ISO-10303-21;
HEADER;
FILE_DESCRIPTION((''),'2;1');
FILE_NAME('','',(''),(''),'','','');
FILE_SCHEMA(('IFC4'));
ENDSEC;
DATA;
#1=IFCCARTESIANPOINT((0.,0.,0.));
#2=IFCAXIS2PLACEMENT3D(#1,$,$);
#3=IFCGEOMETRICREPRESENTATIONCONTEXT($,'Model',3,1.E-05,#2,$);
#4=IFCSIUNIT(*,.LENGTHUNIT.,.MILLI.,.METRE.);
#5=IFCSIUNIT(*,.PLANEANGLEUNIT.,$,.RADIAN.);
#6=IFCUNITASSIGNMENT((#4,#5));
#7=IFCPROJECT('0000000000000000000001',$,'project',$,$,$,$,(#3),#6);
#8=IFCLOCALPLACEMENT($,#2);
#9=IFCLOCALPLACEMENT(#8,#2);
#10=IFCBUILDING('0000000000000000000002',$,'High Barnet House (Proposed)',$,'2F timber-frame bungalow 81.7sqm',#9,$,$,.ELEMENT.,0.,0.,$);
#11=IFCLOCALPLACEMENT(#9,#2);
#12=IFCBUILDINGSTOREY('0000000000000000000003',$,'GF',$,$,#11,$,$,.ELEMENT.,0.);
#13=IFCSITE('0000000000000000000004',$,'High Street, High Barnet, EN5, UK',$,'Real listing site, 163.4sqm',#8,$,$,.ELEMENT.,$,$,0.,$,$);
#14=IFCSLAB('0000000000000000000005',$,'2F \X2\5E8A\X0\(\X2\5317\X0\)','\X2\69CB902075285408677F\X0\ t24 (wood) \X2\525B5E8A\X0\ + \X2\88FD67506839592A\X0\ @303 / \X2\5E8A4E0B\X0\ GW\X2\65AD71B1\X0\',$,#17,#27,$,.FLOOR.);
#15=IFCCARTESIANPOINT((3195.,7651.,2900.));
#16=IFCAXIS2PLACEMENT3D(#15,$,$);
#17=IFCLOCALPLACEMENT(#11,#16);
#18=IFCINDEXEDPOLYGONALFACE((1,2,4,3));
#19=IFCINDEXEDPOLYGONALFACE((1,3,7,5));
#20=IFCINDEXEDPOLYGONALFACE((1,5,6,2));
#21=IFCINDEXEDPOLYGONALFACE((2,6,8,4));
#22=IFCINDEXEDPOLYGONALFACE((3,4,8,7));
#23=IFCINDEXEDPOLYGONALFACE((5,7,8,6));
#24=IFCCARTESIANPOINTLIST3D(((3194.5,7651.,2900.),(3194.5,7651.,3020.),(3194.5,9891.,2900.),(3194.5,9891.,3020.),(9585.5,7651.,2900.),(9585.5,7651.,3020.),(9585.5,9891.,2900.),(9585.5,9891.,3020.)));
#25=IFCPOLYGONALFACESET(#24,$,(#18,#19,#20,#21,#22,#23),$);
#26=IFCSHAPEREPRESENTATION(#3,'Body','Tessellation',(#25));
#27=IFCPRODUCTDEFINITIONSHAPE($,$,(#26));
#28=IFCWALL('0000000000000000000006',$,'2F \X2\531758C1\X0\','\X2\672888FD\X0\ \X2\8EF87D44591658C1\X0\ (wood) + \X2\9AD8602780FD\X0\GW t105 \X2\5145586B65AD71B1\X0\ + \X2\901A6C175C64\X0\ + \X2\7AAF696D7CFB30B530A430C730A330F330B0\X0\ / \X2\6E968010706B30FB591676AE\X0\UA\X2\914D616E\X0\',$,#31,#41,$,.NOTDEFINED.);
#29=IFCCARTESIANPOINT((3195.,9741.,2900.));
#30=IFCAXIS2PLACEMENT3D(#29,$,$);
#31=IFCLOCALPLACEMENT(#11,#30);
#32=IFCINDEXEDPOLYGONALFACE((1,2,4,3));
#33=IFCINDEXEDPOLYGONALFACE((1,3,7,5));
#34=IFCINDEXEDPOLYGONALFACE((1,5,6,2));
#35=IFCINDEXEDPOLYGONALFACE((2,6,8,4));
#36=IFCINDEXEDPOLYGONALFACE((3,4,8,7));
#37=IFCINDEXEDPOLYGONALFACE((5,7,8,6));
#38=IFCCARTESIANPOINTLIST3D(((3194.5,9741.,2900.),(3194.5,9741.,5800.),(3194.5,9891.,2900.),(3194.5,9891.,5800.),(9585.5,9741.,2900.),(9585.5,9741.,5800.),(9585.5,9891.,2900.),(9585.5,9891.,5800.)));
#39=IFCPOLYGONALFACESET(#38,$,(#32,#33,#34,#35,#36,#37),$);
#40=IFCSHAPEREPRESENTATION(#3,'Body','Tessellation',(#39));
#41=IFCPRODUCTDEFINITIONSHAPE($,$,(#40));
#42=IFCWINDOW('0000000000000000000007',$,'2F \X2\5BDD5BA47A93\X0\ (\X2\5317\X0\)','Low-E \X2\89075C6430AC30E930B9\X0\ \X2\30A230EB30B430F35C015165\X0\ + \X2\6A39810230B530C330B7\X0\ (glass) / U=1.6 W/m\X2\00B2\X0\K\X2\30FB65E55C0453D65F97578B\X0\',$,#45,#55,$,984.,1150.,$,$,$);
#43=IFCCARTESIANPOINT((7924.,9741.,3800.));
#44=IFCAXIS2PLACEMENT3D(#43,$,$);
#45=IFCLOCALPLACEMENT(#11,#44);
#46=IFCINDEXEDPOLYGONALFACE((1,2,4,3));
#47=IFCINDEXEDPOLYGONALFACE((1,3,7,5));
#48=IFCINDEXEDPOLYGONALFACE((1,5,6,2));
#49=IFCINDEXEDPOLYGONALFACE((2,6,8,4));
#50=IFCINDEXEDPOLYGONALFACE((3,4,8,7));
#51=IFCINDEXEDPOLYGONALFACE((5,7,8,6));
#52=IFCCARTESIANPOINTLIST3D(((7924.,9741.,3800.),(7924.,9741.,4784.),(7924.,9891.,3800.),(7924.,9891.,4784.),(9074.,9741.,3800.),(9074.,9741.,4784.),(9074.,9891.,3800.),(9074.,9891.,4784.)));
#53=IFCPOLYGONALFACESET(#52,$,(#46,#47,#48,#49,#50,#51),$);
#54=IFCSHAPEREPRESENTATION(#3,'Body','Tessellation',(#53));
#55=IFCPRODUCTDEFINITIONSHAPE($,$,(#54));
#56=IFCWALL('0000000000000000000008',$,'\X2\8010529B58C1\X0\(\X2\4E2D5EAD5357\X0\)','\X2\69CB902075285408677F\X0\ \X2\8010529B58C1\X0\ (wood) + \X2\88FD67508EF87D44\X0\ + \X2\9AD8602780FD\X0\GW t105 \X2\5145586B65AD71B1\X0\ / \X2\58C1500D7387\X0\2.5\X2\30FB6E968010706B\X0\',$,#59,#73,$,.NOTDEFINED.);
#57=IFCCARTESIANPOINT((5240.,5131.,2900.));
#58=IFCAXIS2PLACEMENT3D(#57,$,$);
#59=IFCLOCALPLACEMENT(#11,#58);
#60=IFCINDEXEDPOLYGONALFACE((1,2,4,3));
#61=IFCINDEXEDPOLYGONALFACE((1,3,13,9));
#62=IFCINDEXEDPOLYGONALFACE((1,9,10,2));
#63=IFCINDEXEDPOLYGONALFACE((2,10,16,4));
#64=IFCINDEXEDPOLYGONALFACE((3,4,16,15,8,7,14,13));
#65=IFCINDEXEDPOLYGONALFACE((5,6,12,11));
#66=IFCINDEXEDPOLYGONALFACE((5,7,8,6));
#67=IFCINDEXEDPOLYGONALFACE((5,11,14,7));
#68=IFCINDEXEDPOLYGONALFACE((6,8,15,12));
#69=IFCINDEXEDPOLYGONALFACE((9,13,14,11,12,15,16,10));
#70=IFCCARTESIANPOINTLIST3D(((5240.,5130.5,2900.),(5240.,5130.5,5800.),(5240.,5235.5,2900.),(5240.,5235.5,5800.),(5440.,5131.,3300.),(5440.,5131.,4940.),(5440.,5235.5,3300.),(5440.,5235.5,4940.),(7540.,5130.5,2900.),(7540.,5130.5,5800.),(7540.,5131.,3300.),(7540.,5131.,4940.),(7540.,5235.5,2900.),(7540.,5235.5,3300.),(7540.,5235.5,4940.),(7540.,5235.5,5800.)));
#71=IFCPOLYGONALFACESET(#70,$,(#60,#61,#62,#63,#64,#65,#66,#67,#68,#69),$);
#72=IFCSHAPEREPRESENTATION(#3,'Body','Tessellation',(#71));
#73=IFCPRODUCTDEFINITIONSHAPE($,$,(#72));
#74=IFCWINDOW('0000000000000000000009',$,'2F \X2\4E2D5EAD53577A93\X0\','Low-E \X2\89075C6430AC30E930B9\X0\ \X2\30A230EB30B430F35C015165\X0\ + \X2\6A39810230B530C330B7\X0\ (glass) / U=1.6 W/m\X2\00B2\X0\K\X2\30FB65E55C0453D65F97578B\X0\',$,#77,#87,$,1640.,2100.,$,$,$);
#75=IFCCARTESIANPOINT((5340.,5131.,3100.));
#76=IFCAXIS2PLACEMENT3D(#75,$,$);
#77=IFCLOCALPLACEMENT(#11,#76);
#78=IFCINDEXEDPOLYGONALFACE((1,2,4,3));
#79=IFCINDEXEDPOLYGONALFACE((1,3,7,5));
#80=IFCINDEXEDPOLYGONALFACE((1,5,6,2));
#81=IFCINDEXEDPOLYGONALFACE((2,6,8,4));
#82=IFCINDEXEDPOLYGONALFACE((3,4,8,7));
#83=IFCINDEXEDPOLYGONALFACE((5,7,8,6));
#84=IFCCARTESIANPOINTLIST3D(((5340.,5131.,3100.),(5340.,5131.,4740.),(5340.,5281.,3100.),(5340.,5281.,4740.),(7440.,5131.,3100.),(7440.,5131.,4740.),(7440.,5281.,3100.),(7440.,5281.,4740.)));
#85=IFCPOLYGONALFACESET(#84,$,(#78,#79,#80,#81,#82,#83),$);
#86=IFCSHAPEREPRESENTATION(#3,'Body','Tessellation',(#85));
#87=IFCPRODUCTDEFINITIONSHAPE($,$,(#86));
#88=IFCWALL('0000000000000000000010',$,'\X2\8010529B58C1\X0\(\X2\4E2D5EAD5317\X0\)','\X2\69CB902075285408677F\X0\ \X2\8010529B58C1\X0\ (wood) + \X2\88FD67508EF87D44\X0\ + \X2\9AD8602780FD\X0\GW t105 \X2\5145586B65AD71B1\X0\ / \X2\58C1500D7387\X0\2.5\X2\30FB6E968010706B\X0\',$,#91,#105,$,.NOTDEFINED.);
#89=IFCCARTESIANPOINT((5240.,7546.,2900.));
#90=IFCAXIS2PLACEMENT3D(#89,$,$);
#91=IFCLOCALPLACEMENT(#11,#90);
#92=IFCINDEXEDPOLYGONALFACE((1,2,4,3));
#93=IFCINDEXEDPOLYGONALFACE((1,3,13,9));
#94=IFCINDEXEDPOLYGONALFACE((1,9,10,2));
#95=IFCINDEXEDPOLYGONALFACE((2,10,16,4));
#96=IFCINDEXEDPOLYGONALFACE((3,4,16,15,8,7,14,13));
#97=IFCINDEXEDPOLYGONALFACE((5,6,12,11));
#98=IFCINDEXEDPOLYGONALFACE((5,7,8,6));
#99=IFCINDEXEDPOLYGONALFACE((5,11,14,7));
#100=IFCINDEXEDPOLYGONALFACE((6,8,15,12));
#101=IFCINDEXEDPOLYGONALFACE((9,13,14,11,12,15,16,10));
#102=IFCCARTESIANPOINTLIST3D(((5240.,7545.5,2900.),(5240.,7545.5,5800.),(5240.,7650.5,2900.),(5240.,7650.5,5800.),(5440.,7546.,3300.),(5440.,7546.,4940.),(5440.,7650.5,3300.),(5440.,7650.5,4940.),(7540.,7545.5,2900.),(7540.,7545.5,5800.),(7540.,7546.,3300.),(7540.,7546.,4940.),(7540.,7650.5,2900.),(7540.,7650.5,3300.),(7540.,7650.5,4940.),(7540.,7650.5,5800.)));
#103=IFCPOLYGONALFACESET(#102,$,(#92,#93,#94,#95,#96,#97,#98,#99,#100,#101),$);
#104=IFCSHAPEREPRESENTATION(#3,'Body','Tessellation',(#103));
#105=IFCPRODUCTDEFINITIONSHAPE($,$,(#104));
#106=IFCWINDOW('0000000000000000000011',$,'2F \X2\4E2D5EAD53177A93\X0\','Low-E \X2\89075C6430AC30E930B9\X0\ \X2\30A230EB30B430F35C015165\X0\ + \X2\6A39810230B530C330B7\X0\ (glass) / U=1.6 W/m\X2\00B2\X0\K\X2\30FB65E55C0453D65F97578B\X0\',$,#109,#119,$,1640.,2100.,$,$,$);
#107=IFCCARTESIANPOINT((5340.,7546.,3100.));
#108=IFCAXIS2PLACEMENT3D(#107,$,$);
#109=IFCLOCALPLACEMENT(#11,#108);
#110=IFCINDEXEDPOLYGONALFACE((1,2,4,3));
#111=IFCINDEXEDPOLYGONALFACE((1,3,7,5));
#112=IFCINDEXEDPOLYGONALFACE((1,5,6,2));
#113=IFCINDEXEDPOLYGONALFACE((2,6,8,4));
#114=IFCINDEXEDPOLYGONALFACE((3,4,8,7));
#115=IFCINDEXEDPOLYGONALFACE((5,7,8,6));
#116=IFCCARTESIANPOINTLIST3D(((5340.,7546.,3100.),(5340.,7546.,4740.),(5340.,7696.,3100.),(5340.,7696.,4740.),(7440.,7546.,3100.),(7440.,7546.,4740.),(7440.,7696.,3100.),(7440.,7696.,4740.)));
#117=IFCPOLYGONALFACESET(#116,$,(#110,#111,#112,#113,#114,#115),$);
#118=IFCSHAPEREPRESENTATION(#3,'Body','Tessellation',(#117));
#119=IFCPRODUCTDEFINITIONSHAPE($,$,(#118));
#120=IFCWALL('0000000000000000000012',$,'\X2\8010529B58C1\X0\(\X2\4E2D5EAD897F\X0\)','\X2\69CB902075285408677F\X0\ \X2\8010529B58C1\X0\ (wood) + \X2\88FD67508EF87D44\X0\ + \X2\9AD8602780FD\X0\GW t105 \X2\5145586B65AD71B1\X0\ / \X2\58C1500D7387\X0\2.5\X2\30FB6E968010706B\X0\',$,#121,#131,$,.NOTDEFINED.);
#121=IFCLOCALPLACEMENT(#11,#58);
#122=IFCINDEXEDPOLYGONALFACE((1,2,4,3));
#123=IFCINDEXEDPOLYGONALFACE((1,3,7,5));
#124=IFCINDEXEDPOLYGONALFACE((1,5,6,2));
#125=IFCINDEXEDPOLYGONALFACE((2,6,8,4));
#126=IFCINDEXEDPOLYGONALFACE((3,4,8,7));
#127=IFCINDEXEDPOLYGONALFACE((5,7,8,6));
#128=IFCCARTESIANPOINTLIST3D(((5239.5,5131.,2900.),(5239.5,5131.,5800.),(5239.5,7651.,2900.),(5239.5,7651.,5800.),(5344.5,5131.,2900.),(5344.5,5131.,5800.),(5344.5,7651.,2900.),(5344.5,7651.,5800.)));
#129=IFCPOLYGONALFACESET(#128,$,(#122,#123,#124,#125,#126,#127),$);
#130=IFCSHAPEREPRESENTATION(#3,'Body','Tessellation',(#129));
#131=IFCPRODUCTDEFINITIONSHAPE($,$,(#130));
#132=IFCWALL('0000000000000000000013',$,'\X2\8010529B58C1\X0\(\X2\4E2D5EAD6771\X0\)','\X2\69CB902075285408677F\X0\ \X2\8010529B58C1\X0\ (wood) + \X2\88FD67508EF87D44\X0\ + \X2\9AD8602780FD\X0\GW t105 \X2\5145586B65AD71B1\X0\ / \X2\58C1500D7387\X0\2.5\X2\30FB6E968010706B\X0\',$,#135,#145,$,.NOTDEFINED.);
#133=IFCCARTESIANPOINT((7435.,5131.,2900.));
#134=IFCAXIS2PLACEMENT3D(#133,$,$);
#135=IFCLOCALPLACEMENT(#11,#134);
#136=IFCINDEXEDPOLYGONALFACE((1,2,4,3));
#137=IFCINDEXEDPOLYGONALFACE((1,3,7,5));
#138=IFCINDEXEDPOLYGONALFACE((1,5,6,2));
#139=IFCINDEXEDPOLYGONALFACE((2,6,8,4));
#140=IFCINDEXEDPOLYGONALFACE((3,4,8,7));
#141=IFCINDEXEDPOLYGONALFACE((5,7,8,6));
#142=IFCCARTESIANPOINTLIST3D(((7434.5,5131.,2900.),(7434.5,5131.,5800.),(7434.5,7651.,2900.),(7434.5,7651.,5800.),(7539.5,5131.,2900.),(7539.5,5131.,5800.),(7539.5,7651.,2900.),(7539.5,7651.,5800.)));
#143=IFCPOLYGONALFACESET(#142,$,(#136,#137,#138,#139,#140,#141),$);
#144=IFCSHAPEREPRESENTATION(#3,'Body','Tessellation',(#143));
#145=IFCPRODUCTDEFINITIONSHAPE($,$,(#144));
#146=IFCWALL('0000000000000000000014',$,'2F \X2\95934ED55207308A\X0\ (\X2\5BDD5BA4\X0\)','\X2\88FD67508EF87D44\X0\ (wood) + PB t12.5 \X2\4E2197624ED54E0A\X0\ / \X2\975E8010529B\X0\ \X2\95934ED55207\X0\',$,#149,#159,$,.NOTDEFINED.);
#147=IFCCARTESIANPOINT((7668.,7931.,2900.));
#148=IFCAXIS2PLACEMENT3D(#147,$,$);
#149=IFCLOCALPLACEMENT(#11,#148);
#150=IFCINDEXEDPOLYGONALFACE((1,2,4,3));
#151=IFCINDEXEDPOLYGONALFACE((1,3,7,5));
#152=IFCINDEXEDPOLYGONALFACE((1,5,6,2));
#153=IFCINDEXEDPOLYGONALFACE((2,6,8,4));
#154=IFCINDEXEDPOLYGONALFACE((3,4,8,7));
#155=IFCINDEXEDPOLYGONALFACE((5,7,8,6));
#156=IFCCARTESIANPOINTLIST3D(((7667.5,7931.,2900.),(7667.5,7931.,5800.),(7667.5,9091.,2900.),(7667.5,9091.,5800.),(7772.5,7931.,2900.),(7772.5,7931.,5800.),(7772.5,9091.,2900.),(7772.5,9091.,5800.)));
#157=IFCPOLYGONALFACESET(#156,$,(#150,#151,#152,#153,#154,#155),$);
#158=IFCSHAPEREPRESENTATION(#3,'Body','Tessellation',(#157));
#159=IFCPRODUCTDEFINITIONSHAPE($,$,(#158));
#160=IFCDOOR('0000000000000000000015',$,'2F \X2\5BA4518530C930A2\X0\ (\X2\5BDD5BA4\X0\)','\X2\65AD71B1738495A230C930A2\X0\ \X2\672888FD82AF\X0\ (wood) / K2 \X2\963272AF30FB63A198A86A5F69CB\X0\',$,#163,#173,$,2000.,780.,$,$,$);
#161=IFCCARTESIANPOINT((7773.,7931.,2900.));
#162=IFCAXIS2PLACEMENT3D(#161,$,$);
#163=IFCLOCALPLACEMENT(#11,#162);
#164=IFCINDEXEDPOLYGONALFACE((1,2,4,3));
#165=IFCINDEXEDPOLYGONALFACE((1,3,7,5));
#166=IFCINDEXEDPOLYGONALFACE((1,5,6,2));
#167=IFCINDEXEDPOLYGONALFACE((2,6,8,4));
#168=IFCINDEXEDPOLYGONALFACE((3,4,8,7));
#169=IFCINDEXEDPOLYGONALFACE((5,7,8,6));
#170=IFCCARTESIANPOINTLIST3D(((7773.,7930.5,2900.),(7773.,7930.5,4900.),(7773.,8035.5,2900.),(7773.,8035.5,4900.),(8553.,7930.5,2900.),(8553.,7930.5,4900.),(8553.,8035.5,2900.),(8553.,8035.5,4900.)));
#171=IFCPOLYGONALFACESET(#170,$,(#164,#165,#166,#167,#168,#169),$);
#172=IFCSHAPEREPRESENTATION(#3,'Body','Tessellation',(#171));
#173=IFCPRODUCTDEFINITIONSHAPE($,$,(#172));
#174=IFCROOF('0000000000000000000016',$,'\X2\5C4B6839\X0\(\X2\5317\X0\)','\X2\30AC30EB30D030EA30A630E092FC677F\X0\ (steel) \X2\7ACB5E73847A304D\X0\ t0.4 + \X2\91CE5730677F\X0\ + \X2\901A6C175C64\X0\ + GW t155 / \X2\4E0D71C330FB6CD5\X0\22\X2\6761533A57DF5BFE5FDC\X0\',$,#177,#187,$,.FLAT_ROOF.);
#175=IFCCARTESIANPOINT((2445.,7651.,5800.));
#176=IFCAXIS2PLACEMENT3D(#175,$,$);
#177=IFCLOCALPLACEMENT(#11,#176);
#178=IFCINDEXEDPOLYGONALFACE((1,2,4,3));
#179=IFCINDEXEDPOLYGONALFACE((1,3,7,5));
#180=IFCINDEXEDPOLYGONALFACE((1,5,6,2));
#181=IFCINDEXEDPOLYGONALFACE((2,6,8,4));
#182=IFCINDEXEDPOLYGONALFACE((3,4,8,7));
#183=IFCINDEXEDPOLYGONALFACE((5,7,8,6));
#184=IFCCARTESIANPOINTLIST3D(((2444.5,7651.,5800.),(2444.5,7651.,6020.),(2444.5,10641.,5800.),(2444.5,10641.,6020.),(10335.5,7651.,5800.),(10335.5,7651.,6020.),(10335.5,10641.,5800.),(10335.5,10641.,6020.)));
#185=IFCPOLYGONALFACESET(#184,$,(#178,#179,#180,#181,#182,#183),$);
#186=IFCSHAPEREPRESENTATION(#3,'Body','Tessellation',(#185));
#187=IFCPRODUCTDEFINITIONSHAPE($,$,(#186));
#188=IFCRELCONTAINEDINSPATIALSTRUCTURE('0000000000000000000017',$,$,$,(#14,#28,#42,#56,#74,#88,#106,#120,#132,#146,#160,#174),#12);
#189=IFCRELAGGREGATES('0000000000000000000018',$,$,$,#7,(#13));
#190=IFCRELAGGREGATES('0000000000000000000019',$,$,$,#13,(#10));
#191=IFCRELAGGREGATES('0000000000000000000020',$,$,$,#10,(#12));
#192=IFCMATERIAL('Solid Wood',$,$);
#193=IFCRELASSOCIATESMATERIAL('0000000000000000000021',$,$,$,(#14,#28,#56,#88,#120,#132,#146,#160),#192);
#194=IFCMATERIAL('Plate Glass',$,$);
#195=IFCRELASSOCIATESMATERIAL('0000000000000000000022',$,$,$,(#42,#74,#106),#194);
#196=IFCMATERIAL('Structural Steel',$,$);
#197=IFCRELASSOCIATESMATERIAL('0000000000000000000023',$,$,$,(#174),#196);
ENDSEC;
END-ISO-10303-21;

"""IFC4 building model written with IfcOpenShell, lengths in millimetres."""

from ifc_helpers import new_model, si_unit, frame, frame_2d, origin, place, context, project, spatial, rectangle, extrude, material, element, fill, save


model = new_model("IFC4")

# Units and contexts
model_context = context("Model", 3, precision=1e-05, world=origin())
ifc_project = project(units=[si_unit("LENGTHUNIT", "METRE", prefix="MILLI"), si_unit("PLANEANGLEUNIT", "RADIAN")], contexts=[model_context])

# Site, building, storey
site_placement = place(None, origin())
site = spatial("IfcSite", under=ifc_project, at=site_placement, Name="High Street, High Barnet, EN5, UK", ObjectType="Real listing site, 163.4sqm", CompositionType="ELEMENT", RefElevation=0.0)
building_placement = place(site_placement, origin())
building = spatial("IfcBuilding", under=site, at=building_placement, Name="High Barnet House (Proposed)", ObjectType="2F timber-frame bungalow 81.7sqm", CompositionType="ELEMENT", ElevationOfRefHeight=0.0, ElevationOfTerrain=0.0)
storey_placement = place(building_placement, origin())
storey = spatial("IfcBuildingStorey", under=building, at=storey_placement, Name="GF", CompositionType="ELEMENT", Elevation=0.0)

# Slab
ifc_material_1 = material(Name="Solid Wood")
slab_placement = place(storey_placement, frame((3195.0, 7651.0, 2900.0)))
element("IfcSlab", 1, at=slab_placement, inside=storey, material=ifc_material_1, Name="2F 床(北)", Description="構造用合板 t24 (wood) 剛床 + 製材根太 @303 / 床下 GW断熱", PredefinedType="FLOOR", context=model_context, shape_type="SweptSolid", body=[
    extrude(rectangle(XDim=6391.0, YDim=2240.0, at=frame_2d((3195.0, 1120.0))), frame((3195.0, 7651.0, 2900.0)), (0.0, 0.0, 1.0), 120.0),
])

# Walls, openings, windows
wall_1_placement = place(storey_placement, frame((3195.0, 9741.0, 2900.0)))
wall_1 = element("IfcWall", 2, at=wall_1_placement, inside=storey, material=ifc_material_1, Name="2F 北壁", Description="木製 軸組外壁 (wood) + 高性能GW t105 充填断熱 + 通気層 + 窯業系サイディング / 準耐火・外皮UA配慮", PredefinedType="NOTDEFINED", context=model_context, shape_type="SweptSolid", body=[
    extrude(rectangle(XDim=6391.0, YDim=150.0, at=frame_2d((3195.0, 75.0))), frame((3195.0, 9741.0, 2900.0)), (0.0, 0.0, 1.0), 2900.0),
])
opening_1_placement = place(storey_placement, frame((7924.0, 9741.0, 3800.0)))
opening_1 = element("IfcOpeningElement", 3, at=opening_1_placement, cuts=wall_1, PredefinedType="NOTDEFINED", context=model_context, shape_type="SweptSolid", body=[
    extrude(rectangle(XDim=1150.0, YDim=150.0, at=frame_2d((575.0, 75.0))), frame((7924.0, 9741.0, 3800.0)), (0.0, 0.0, 1.0), 984.0),
])
ifc_material_2 = material(Name="Plate Glass")
window_1_placement = place(storey_placement, frame((7924.0, 9741.0, 3800.0)))
window_1 = element("IfcWindow", 4, at=window_1_placement, inside=storey, material=ifc_material_2, Name="2F 寝室窓 (北)", Description="Low-E 複層ガラス アルゴン封入 + 樹脂サッシ (glass) / U=1.6 W/m²K・日射取得型", OverallHeight=984.0, OverallWidth=1150.0, context=model_context, shape_type="SweptSolid", body=[
    extrude(rectangle(XDim=1150.0, YDim=150.0, at=frame_2d((575.0, 75.0))), frame((7924.0, 9741.0, 3800.0)), (0.0, 0.0, 1.0), 984.0),
])
fill(opening_1, window_1)
wall_2_placement = place(storey_placement, frame((5240.0, 5131.0, 2900.0)))
wall_2 = element("IfcWall", 5, at=wall_2_placement, inside=storey, material=ifc_material_1, Name="耐力壁(中庭南)", Description="構造用合板 耐力壁 (wood) + 製材軸組 + 高性能GW t105 充填断熱 / 壁倍率2.5・準耐火", PredefinedType="NOTDEFINED", context=model_context, shape_type="SweptSolid", body=[
    extrude(rectangle(XDim=2300.0, YDim=105.0, at=frame_2d((1150.0, 52.0))), frame((5240.0, 5131.0, 2900.0)), (0.0, 0.0, 1.0), 2900.0),
])
opening_2_placement = place(storey_placement, frame((5340.0, 5131.0, 3100.0)))
opening_2 = element("IfcOpeningElement", 6, at=opening_2_placement, cuts=wall_2, PredefinedType="NOTDEFINED", context=model_context, shape_type="SweptSolid", body=[
    extrude(rectangle(XDim=2100.0, YDim=150.0, at=frame_2d((1050.0, 75.0))), frame((5340.0, 5131.0, 3100.0)), (0.0, 0.0, 1.0), 1640.0),
])
window_2_placement = place(storey_placement, frame((5340.0, 5131.0, 3100.0)))
window_2 = element("IfcWindow", 7, at=window_2_placement, inside=storey, material=ifc_material_2, Name="2F 中庭南窓", Description="Low-E 複層ガラス アルゴン封入 + 樹脂サッシ (glass) / U=1.6 W/m²K・日射取得型", OverallHeight=1640.0, OverallWidth=2100.0, context=model_context, shape_type="SweptSolid", body=[
    extrude(rectangle(XDim=2100.0, YDim=150.0, at=frame_2d((1050.0, 75.0))), frame((5340.0, 5131.0, 3100.0)), (0.0, 0.0, 1.0), 1640.0),
])
fill(opening_2, window_2)
wall_3_placement = place(storey_placement, frame((5240.0, 7546.0, 2900.0)))
wall_3 = element("IfcWall", 8, at=wall_3_placement, inside=storey, material=ifc_material_1, Name="耐力壁(中庭北)", Description="構造用合板 耐力壁 (wood) + 製材軸組 + 高性能GW t105 充填断熱 / 壁倍率2.5・準耐火", PredefinedType="NOTDEFINED", context=model_context, shape_type="SweptSolid", body=[
    extrude(rectangle(XDim=2300.0, YDim=105.0, at=frame_2d((1150.0, 52.0))), frame((5240.0, 7546.0, 2900.0)), (0.0, 0.0, 1.0), 2900.0),
])
opening_3_placement = place(storey_placement, frame((5340.0, 7546.0, 3100.0)))
opening_3 = element("IfcOpeningElement", 9, at=opening_3_placement, cuts=wall_3, PredefinedType="NOTDEFINED", context=model_context, shape_type="SweptSolid", body=[
    extrude(rectangle(XDim=2100.0, YDim=150.0, at=frame_2d((1050.0, 75.0))), frame((5340.0, 7546.0, 3100.0)), (0.0, 0.0, 1.0), 1640.0),
])
window_3_placement = place(storey_placement, frame((5340.0, 7546.0, 3100.0)))
window_3 = element("IfcWindow", 10, at=window_3_placement, inside=storey, material=ifc_material_2, Name="2F 中庭北窓", Description="Low-E 複層ガラス アルゴン封入 + 樹脂サッシ (glass) / U=1.6 W/m²K・日射取得型", OverallHeight=1640.0, OverallWidth=2100.0, context=model_context, shape_type="SweptSolid", body=[
    extrude(rectangle(XDim=2100.0, YDim=150.0, at=frame_2d((1050.0, 75.0))), frame((5340.0, 7546.0, 3100.0)), (0.0, 0.0, 1.0), 1640.0),
])
fill(opening_3, window_3)

# Walls
wall_4_placement = place(storey_placement, frame((5240.0, 5131.0, 2900.0)))
element("IfcWall", 11, at=wall_4_placement, inside=storey, material=ifc_material_1, Name="耐力壁(中庭西)", Description="構造用合板 耐力壁 (wood) + 製材軸組 + 高性能GW t105 充填断熱 / 壁倍率2.5・準耐火", PredefinedType="NOTDEFINED", context=model_context, shape_type="SweptSolid", body=[
    extrude(rectangle(XDim=105.0, YDim=2520.0, at=frame_2d((52.0, 1260.0))), frame((5240.0, 5131.0, 2900.0)), (0.0, 0.0, 1.0), 2900.0),
])
wall_5_placement = place(storey_placement, frame((7435.0, 5131.0, 2900.0)))
element("IfcWall", 12, at=wall_5_placement, inside=storey, material=ifc_material_1, Name="耐力壁(中庭東)", Description="構造用合板 耐力壁 (wood) + 製材軸組 + 高性能GW t105 充填断熱 / 壁倍率2.5・準耐火", PredefinedType="NOTDEFINED", context=model_context, shape_type="SweptSolid", body=[
    extrude(rectangle(XDim=105.0, YDim=2520.0, at=frame_2d((52.0, 1260.0))), frame((7435.0, 5131.0, 2900.0)), (0.0, 0.0, 1.0), 2900.0),
])
wall_6_placement = place(storey_placement, frame((7668.0, 7931.0, 2900.0)))
element("IfcWall", 13, at=wall_6_placement, inside=storey, material=ifc_material_1, Name="2F 間仕切り (寝室)", Description="製材軸組 (wood) + PB t12.5 両面仕上 / 非耐力 間仕切", PredefinedType="NOTDEFINED", context=model_context, shape_type="SweptSolid", body=[
    extrude(rectangle(XDim=105.0, YDim=1160.0, at=frame_2d((52.0, 580.0))), frame((7668.0, 7931.0, 2900.0)), (0.0, 0.0, 1.0), 2900.0),
])

# Door
door_placement = place(storey_placement, frame((7773.0, 7931.0, 2900.0)))
element("IfcDoor", 14, at=door_placement, inside=storey, material=ifc_material_1, Name="2F 室内ドア (寝室)", Description="断熱玄関ドア 木製芯 (wood) / K2 防犯・採風機構", OverallHeight=2000.0, OverallWidth=780.0, context=model_context, shape_type="SweptSolid", body=[
    extrude(rectangle(XDim=780.0, YDim=105.0, at=frame_2d((390.0, 52.0))), frame((7773.0, 7931.0, 2900.0)), (0.0, 0.0, 1.0), 2000.0),
])

# Roof
ifc_material_3 = material(Name="Structural Steel")
for number, where, name in (
    (15, (2445.0, 7651.0, 5800.0), "屋根(北)"),
):
    element("IfcRoof", number, at=place(storey_placement, frame(where)), inside=storey, material=ifc_material_3, Name=name, Description="ガルバリウム鋼板 (steel) 立平葺き t0.4 + 野地板 + 通気層 + GW t155 / 不燃・法22条区域対応", PredefinedType="FLAT_ROOF", context=model_context, shape_type="SweptSolid", body=[
        extrude(rectangle(XDim=7891.0, YDim=2990.0, at=frame_2d((3945.0, 1495.0))), frame((2445.0, 7651.0, 5800.0)), (0.0, 0.0, 1.0), 220.0),
    ])

save(model, "model.ifc")
